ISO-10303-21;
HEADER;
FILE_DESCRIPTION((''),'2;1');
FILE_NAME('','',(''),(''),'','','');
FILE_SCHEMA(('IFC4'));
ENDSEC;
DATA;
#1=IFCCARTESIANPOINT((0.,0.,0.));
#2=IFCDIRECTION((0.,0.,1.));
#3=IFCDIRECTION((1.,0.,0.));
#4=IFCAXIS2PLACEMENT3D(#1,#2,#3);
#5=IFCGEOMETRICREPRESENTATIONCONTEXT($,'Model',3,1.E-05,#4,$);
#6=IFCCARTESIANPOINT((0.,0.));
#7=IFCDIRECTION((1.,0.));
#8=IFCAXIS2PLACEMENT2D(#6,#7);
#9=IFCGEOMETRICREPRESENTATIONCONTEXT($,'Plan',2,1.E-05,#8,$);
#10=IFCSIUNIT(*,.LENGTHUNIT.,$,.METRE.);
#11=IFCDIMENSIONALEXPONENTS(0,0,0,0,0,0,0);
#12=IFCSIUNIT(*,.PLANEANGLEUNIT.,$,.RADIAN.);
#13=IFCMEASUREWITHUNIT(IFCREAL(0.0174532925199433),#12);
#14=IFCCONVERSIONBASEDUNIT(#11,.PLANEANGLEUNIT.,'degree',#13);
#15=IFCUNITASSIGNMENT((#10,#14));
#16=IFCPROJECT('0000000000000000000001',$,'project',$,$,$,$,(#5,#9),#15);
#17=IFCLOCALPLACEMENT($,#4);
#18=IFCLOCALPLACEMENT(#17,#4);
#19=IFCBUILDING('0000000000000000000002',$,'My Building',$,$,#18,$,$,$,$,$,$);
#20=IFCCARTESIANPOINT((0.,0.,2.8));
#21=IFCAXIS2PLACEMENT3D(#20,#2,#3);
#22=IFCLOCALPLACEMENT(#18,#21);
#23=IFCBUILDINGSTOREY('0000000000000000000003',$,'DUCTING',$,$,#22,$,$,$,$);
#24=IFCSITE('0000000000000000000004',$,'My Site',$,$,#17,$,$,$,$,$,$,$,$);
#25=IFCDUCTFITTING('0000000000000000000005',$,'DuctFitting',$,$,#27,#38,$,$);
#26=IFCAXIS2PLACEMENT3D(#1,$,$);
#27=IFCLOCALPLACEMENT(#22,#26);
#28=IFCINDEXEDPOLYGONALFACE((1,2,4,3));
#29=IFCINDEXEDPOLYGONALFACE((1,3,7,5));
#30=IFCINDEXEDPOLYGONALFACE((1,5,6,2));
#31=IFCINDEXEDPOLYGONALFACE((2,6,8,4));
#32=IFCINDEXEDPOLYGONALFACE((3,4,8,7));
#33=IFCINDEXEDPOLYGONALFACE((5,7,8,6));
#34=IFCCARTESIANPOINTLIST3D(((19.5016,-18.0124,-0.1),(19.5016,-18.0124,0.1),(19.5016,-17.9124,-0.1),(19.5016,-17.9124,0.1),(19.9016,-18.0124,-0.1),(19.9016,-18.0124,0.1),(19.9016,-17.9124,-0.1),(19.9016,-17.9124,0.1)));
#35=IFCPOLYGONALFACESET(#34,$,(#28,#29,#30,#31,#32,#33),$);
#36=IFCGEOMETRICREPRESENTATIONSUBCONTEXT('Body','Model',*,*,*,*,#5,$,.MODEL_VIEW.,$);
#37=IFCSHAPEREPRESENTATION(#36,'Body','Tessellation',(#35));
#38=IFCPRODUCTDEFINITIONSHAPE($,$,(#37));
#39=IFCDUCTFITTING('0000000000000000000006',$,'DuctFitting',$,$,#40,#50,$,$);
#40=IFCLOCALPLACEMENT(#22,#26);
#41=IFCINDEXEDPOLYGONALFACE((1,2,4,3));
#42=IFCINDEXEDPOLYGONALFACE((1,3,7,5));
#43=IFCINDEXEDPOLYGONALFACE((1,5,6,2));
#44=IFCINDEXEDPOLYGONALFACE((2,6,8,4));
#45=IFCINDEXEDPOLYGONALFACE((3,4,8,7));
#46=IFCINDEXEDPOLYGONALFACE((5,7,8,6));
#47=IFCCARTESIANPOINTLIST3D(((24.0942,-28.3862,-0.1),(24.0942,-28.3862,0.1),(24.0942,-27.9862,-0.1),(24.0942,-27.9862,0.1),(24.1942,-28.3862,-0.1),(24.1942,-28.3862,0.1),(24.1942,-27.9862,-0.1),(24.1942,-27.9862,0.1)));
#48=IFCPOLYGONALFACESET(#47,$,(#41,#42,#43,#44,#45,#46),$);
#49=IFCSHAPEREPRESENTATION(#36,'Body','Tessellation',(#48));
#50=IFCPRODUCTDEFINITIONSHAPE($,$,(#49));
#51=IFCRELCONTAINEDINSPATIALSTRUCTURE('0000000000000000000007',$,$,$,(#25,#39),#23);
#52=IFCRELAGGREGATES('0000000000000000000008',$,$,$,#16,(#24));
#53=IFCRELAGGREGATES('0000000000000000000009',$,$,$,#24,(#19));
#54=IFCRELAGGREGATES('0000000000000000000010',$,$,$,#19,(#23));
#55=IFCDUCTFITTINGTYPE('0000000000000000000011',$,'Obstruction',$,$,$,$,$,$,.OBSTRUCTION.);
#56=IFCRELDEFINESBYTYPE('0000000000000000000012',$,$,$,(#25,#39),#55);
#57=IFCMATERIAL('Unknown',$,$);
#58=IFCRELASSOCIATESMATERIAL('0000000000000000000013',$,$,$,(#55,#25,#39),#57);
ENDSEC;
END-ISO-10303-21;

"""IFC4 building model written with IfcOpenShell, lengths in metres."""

from ifc_helpers import new_model, entity, si_unit, converted_unit, frame, origin_with_axes, origin_2d_with_axis, place, context, subcontext, project, spatial, rectangle, extrude, material, material_profile, profile_set, profile_usage, type_object, element, save


model = new_model("IFC4")

# Units and contexts
model_context = context("Model", 3, precision=1e-05, world=origin_with_axes())
plan_context = context("Plan", 2, precision=1e-05, world=origin_2d_with_axis())
body_context = subcontext(model_context, "Body", "Model", "MODEL_VIEW")
ifc_project = project(units=[si_unit("LENGTHUNIT", "METRE"), converted_unit("PLANEANGLEUNIT", "degree", entity("IfcReal", 0.0174532925199433), si_unit("PLANEANGLEUNIT", "RADIAN"), dimensions=[0, 0, 0, 0, 0, 0, 0])], contexts=[model_context, plan_context])

# Site, building, storey
site_placement = place(None, origin_with_axes())
site = spatial("IfcSite", under=ifc_project, at=site_placement, Name="My Site")
building_placement = place(site_placement, origin_with_axes())
building = spatial("IfcBuilding", under=site, at=building_placement, Name="My Building")
storey_placement = place(building_placement, frame((0.0, 0.0, 2.8), z_axis=(0.0, 0.0, 1.0), x_axis=(1.0, 0.0, 0.0)))
storey = spatial("IfcBuildingStorey", under=building, at=storey_placement, Name="DUCTING")

# Shared definitions
ifc_material = material(Name="Unknown")

# Duct fittings
ifc_material_profile_1 = material_profile(ifc_material, rectangle(XDim=0.4, YDim=0.2))
ifc_profile_set_1 = profile_set([ifc_material_profile_1])
duct_fitting_type_1 = type_object("IfcDuctFittingType", Name="Obstruction", PredefinedType="OBSTRUCTION", material=ifc_profile_set_1)
ifc_profile_usage_1 = profile_usage(ifc_profile_set_1, cardinal=5)
duct_fitting_1_placement = place(storey_placement, frame((19.7016, -17.9124, 0.0), z_axis=(0.0, -1.0, 0.0), x_axis=(1.0, 0.0, 0.0)))
element("IfcDuctFitting", 1, at=duct_fitting_1_placement, inside=storey, type_object=duct_fitting_type_1, material=ifc_profile_usage_1, Name="DuctFitting", context=body_context, shape_type="SweptSolid", body=[
    extrude(rectangle(XDim=0.4, YDim=0.2), origin_with_axes(), (0.0, 0.0, 1.0), 0.1),
])
ifc_profile_usage_2 = profile_usage(ifc_profile_set_1, cardinal=5)
duct_fitting_2_placement = place(storey_placement, frame((24.0942, -28.1862, 0.0), z_axis=(1.0, 0.0, 0.0), x_axis=(0.0, 1.0, 0.0)))
element("IfcDuctFitting", 2, at=duct_fitting_2_placement, inside=storey, type_object=duct_fitting_type_1, material=ifc_profile_usage_2, Name="DuctFitting", context=body_context, shape_type="SweptSolid", body=[
    extrude(rectangle(XDim=0.4, YDim=0.2), origin_with_axes(), (0.0, 0.0, 1.0), 0.1),
])

save(model, "model.ifc")
